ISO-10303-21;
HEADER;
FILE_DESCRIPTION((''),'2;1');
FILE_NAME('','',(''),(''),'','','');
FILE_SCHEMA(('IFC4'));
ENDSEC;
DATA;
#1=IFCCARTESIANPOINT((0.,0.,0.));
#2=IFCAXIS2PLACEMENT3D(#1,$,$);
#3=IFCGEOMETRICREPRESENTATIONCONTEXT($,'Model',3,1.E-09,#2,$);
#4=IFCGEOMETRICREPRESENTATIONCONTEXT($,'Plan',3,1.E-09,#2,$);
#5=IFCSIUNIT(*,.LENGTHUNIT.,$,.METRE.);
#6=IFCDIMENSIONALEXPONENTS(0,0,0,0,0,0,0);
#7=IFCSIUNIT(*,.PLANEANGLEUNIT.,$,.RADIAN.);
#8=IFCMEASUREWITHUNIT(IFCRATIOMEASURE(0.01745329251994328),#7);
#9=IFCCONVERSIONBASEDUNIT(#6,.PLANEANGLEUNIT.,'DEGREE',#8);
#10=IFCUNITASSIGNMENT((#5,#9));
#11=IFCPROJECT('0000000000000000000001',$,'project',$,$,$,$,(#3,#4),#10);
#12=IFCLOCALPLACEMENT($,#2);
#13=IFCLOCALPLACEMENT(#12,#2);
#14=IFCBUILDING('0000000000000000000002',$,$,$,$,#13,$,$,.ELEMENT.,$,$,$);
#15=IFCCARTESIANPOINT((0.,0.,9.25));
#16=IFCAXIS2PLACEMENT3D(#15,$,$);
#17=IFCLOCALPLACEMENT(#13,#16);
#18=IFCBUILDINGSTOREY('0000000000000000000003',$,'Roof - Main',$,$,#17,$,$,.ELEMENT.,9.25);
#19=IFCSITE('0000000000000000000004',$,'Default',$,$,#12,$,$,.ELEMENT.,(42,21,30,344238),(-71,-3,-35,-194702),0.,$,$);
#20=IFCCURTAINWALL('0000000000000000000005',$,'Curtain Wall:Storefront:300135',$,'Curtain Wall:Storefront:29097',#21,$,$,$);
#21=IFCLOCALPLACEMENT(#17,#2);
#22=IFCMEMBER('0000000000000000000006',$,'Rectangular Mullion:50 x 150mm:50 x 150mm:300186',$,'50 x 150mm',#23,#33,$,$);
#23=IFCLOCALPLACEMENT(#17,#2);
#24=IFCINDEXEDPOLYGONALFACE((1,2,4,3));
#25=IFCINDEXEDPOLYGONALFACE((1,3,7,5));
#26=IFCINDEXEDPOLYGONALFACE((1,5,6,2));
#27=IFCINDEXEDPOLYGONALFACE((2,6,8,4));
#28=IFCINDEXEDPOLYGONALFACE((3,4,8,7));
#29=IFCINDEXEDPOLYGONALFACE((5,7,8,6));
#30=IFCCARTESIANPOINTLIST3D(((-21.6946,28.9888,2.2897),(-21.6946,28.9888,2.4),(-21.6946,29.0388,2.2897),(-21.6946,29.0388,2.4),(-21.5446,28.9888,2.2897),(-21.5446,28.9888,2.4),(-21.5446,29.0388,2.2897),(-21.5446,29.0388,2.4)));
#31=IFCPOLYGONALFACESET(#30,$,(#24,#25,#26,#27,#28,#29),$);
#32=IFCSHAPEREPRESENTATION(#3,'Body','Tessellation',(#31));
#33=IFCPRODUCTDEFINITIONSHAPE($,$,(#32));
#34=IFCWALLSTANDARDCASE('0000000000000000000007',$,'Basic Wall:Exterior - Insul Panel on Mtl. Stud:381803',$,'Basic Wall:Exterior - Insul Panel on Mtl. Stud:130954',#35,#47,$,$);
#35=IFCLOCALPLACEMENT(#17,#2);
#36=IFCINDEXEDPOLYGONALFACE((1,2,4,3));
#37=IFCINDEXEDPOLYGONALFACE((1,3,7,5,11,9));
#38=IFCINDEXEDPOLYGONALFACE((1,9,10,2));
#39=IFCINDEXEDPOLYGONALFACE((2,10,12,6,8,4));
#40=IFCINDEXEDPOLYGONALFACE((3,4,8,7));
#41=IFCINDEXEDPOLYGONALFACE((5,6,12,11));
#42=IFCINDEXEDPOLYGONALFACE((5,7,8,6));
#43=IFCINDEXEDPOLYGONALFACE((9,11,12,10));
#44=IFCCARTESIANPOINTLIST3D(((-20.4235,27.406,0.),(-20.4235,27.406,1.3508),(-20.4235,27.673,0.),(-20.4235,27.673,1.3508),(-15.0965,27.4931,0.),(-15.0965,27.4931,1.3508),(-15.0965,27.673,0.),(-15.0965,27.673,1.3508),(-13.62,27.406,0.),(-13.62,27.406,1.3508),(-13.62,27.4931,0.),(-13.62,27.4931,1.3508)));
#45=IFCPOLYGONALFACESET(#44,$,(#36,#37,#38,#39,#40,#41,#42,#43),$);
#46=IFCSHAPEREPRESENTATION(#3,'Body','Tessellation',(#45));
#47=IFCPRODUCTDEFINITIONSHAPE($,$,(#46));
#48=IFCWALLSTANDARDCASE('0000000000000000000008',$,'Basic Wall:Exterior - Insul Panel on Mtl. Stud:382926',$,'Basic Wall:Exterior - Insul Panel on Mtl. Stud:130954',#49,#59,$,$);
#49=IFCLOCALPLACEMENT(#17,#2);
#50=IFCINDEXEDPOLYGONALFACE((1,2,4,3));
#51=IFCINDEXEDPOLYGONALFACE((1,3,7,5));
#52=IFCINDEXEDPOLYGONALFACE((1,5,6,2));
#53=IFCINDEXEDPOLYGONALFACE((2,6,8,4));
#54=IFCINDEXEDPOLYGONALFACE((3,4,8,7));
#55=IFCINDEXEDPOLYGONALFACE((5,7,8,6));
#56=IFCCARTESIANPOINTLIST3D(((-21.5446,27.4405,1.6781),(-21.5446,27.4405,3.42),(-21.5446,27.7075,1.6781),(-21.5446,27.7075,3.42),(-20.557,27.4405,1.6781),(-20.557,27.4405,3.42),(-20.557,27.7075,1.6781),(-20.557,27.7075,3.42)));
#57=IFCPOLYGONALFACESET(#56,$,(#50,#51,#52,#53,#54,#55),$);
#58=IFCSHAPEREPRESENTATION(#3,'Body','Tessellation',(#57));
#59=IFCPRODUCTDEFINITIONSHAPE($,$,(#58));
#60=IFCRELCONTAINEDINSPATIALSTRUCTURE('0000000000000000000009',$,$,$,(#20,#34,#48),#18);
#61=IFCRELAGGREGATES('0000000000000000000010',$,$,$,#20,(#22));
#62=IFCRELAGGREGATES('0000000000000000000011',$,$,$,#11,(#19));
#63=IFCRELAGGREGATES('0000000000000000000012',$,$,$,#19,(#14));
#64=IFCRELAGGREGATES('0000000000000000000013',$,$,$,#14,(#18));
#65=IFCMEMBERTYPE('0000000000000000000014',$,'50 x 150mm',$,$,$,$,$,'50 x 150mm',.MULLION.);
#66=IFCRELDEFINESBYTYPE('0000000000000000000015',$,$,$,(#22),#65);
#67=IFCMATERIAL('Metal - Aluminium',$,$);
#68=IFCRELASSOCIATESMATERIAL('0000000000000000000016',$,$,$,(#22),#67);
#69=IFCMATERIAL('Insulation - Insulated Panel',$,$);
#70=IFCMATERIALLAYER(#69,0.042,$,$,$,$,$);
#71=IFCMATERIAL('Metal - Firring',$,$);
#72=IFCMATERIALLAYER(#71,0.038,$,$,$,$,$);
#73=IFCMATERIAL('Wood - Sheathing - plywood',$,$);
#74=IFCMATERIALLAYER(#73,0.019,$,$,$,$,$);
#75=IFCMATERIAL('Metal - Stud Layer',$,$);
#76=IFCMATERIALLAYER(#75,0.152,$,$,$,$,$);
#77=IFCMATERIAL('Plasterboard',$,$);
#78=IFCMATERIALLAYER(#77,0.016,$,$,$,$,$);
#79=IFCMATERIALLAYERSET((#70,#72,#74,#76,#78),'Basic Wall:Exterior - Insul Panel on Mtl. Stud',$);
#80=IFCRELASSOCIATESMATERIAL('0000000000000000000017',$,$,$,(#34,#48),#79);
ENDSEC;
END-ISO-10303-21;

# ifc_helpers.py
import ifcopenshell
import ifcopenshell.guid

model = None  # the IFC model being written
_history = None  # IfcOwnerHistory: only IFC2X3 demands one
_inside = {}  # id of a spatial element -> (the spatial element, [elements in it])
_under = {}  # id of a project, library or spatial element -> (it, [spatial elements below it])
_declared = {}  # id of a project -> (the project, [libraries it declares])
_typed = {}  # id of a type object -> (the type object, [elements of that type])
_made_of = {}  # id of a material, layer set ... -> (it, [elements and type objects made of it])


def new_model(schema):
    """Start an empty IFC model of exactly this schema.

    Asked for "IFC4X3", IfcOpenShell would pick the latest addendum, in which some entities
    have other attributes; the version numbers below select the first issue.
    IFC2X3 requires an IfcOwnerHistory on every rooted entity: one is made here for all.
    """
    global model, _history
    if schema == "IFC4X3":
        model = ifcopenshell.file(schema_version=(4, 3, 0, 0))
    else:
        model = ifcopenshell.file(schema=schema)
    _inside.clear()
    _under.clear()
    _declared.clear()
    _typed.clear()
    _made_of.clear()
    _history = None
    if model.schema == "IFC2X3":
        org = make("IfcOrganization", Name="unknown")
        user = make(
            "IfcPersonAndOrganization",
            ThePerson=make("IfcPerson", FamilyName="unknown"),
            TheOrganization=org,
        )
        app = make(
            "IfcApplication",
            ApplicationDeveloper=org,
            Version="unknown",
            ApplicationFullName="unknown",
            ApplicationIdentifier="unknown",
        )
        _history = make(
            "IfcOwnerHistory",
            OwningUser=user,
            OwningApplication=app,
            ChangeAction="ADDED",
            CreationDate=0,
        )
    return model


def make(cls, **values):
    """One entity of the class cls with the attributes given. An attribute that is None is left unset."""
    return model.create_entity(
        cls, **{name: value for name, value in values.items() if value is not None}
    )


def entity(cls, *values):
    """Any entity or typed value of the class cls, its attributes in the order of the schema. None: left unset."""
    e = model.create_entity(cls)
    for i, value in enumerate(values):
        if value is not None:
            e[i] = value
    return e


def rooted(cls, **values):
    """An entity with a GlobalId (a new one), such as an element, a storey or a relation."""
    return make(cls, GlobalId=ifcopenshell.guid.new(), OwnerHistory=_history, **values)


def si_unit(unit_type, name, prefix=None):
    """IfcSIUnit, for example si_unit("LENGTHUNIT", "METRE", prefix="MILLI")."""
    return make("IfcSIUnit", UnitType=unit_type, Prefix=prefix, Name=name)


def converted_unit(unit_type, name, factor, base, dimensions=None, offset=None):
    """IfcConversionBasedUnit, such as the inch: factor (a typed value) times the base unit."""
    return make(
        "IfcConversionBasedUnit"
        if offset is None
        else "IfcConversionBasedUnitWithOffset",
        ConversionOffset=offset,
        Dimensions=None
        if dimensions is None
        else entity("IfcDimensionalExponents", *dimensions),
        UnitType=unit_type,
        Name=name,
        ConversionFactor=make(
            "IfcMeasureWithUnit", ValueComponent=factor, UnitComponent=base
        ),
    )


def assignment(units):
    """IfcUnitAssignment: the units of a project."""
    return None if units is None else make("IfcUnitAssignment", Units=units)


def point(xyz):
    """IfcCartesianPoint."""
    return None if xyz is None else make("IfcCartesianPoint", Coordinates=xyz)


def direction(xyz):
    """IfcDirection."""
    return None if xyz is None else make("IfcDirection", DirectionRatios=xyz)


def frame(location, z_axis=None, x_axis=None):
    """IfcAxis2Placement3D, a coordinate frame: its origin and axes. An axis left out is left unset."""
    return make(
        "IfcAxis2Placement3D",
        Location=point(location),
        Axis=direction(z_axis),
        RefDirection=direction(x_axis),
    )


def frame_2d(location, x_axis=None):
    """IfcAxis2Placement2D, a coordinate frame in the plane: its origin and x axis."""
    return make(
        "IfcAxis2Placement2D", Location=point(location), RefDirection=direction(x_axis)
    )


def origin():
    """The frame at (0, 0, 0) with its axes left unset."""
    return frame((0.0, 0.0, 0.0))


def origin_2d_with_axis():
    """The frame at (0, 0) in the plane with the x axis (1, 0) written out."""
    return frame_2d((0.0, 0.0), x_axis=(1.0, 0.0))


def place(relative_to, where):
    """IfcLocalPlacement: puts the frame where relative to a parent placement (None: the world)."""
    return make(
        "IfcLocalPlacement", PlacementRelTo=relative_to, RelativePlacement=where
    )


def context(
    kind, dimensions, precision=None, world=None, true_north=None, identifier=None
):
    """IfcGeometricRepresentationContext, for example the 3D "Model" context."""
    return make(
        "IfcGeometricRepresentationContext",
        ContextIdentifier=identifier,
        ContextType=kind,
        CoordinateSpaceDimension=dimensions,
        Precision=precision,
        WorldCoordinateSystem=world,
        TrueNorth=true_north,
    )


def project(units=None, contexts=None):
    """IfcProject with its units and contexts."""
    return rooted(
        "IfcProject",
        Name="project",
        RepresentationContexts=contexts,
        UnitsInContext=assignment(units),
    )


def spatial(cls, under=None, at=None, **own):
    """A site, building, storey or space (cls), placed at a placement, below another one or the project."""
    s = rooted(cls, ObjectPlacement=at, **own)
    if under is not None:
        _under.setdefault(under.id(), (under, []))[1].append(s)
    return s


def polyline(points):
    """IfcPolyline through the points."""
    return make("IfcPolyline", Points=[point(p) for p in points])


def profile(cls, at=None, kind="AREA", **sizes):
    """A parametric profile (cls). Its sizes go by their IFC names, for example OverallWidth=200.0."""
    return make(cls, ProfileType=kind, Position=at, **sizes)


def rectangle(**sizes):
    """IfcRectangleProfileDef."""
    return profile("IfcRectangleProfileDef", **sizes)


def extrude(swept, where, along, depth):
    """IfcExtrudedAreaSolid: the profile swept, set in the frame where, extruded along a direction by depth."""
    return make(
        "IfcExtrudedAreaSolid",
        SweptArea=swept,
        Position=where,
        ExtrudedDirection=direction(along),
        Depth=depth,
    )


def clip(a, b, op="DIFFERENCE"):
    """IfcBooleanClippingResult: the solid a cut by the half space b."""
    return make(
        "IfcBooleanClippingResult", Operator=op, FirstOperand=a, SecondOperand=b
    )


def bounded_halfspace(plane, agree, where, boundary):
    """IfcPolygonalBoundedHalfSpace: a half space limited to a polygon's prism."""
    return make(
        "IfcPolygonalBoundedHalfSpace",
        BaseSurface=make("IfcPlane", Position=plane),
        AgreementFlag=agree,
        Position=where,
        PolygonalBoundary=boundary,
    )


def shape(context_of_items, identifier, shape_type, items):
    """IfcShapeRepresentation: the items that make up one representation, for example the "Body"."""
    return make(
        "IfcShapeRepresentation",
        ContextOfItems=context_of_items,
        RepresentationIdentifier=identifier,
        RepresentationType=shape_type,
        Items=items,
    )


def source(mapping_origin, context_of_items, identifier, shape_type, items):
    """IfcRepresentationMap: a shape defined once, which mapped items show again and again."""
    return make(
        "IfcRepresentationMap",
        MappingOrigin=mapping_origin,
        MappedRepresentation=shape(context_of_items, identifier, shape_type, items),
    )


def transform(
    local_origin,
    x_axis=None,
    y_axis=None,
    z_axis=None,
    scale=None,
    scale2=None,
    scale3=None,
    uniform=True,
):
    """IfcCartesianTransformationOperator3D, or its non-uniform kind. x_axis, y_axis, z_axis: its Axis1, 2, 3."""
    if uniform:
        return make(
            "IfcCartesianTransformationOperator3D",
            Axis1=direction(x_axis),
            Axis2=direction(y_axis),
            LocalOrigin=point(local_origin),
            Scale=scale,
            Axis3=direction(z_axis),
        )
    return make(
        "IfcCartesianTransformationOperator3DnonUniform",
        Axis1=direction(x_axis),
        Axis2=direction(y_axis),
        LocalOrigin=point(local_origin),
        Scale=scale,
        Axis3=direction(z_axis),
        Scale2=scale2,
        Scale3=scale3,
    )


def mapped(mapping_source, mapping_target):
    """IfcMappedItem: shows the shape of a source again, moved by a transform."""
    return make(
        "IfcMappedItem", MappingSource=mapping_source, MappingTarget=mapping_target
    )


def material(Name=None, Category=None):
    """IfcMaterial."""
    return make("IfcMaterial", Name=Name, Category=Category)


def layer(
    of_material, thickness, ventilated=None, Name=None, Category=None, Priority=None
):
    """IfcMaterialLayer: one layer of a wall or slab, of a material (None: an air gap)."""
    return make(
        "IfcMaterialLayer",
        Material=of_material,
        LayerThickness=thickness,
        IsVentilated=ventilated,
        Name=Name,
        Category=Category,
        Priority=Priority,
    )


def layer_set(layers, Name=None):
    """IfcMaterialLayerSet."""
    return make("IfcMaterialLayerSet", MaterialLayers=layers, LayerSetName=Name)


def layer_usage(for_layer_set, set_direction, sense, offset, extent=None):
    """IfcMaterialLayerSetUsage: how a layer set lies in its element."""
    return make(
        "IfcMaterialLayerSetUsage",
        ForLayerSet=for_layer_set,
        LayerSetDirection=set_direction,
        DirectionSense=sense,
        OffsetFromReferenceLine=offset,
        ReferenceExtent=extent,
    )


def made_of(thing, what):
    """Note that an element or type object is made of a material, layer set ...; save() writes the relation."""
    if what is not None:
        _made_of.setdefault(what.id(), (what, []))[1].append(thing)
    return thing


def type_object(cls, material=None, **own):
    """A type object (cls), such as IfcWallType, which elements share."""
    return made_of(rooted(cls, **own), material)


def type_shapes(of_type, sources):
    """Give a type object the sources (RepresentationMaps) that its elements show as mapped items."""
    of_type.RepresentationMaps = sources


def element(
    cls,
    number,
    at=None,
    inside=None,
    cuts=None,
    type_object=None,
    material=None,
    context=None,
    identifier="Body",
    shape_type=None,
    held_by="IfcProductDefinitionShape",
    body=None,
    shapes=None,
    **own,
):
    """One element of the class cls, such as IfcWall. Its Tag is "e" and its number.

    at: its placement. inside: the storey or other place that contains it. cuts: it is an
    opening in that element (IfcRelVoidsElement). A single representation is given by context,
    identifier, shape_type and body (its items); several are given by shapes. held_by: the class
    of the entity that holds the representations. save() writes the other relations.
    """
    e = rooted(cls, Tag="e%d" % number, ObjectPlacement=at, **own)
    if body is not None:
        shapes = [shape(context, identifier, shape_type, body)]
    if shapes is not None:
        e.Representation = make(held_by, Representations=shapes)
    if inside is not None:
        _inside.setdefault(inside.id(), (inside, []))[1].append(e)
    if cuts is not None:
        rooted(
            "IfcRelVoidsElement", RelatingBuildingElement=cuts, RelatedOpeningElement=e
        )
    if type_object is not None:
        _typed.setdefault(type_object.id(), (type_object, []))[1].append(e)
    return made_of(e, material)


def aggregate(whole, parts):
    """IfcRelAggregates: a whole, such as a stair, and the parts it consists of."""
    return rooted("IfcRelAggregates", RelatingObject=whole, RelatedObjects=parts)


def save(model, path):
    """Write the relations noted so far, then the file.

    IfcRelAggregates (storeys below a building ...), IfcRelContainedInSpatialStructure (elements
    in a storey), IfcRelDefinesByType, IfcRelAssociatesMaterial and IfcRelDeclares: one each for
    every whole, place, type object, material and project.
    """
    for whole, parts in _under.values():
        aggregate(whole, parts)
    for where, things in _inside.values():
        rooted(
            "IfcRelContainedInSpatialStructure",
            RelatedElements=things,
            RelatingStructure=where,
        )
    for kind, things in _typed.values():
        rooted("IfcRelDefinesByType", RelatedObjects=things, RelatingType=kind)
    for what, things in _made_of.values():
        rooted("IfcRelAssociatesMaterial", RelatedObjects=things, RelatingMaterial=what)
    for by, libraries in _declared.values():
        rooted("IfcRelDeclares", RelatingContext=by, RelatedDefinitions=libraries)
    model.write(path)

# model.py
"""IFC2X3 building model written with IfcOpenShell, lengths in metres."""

from ifc_helpers import new_model, entity, si_unit, converted_unit, frame, frame_2d, origin, origin_2d_with_axis, place, context, project, spatial, polyline, rectangle, extrude, clip, bounded_halfspace, source, transform, mapped, material, layer, layer_set, layer_usage, type_object, type_shapes, element, aggregate, save


model = new_model("IFC2X3")

# Units and contexts
model_context = context("Model", 3, precision=1e-09, world=origin())
plan_context = context("Plan", 3, precision=1e-09, world=origin())
ifc_project = project(units=[si_unit("LENGTHUNIT", "METRE"), converted_unit("PLANEANGLEUNIT", "DEGREE", entity("IfcRatioMeasure", 0.01745329251994328), si_unit("PLANEANGLEUNIT", "RADIAN"), dimensions=[0, 0, 0, 0, 0, 0, 0])], contexts=[model_context, plan_context])

# Site, building, storey
site_placement = place(None, origin())
site = spatial("IfcSite", under=ifc_project, at=site_placement, Name="Default", CompositionType="ELEMENT", RefLatitude=(42, 21, 30, 344238), RefLongitude=(-71, -3, -35, -194702), RefElevation=0.0)
building_placement = place(site_placement, origin())
building = spatial("IfcBuilding", under=site, at=building_placement, CompositionType="ELEMENT")
storey_placement = place(building_placement, frame((0.0, 0.0, 9.25)))
storey = spatial("IfcBuildingStorey", under=building, at=storey_placement, Name="Roof - Main", CompositionType="ELEMENT", Elevation=9.25)

# Curtain wall, member
ifc_material_1 = material(Name="Metal - Aluminium")
curtain_wall_1_placement = place(storey_placement, origin())
curtain_wall_1 = element("IfcCurtainWall", 1, at=curtain_wall_1_placement, inside=storey, Name="Curtain Wall:Storefront:300135", ObjectType="Curtain Wall:Storefront:29097")
member_type_1 = type_object("IfcMemberType", Name="50 x 150mm", ElementType="50 x 150mm", PredefinedType="MULLION")
shared_shape_1 = source(origin(), model_context, "Body", "SweptSolid", [
    extrude(rectangle(XDim=0.05, YDim=0.15, at=origin_2d_with_axis()), frame((0.0, 0.0, -0.1103), z_axis=(0.0, 0.0, 1.0), x_axis=(-1.0, 0.0, 0.0)), (0.0, 0.0, 1.0), 0.1103),
])
type_shapes(member_type_1, [shared_shape_1])
member_1_placement = place(storey_placement, frame((-21.6196, 29.0138, 2.2897), z_axis=(0.0, 0.0, -1.0), x_axis=(0.0, -1.0, 0.0)))
member_1 = element("IfcMember", 2, at=member_1_placement, type_object=member_type_1, material=ifc_material_1, Name="Rectangular Mullion:50 x 150mm:50 x 150mm:300186", ObjectType="50 x 150mm", context=model_context, shape_type="MappedRepresentation", body=[
    mapped(shared_shape_1, transform((0.0, 0.0, 0.0), scale=1.0)),
])

aggregate(curtain_wall_1, [member_1])

# Walls
ifc_material_2 = material(Name="Insulation - Insulated Panel")
ifc_layer_1 = layer(ifc_material_2, 0.042)
ifc_material_3 = material(Name="Metal - Firring")
ifc_layer_2 = layer(ifc_material_3, 0.038)
ifc_material_4 = material(Name="Wood - Sheathing - plywood")
ifc_layer_3 = layer(ifc_material_4, 0.019)
ifc_material_5 = material(Name="Metal - Stud Layer")
ifc_layer_4 = layer(ifc_material_5, 0.152)
ifc_material_6 = material(Name="Plasterboard")
ifc_layer_5 = layer(ifc_material_6, 0.016)
ifc_layer_set = layer_set([ifc_layer_1, ifc_layer_2, ifc_layer_3, ifc_layer_4, ifc_layer_5], Name="Basic Wall:Exterior - Insul Panel on Mtl. Stud")
ifc_layer_usage_1 = layer_usage(ifc_layer_set, "AXIS2", "POSITIVE", -0.1335)
wall_1_placement = place(storey_placement, frame((-20.4235, 27.5395, 0.0)))
element("IfcWallStandardCase", 3, at=wall_1_placement, inside=storey, material=ifc_layer_usage_1, Name="Basic Wall:Exterior - Insul Panel on Mtl. Stud:381803", ObjectType="Basic Wall:Exterior - Insul Panel on Mtl. Stud:130954", context=model_context, shape_type="Clipping", body=[
    clip(clip(extrude(rectangle(XDim=6.8035, YDim=0.267, at=frame_2d((3.4018, 0.0), x_axis=(-1.0, 0.0))), origin(), (0.0, 0.0, 1.0), 1.3508), bounded_halfspace(frame((5.327, -0.0464, 0.0), z_axis=(0.0, -1.0, 0.0), x_axis=(1.0, 0.0, 0.0)), True, frame((5.327, -0.0464, 0.0), z_axis=(0.0, -1.0, 0.0), x_axis=(1.0, 0.0, 0.0)), polyline([(0.0, 0.0), (1.4765, 0.0), (1.4765, 0.457), (1.4765, 1.3508), (0.0, 1.3508), (0.0, 0.0)]))), bounded_halfspace(frame((5.327, -0.0464, 1.3508), z_axis=(-1.0, 0.0, 0.0), x_axis=(0.0, -1.0, 0.0)), True, frame((5.327, -0.0464, 1.3508), z_axis=(-1.0, 0.0, 0.0), x_axis=(0.0, -1.0, 0.0)), polyline([(0.0, 0.0), (-0.1799, 0.0), (-0.1799, -0.0008), (-0.1799, -1.3508), (0.0, -1.3508), (0.0, 0.0)]))),
])
ifc_layer_usage_2 = layer_usage(ifc_layer_set, "AXIS2", "NEGATIVE", 0.1335)
wall_2_placement = place(storey_placement, frame((-21.5446, 27.574, 1.6781)))
element("IfcWallStandardCase", 4, at=wall_2_placement, inside=storey, material=ifc_layer_usage_2, Name="Basic Wall:Exterior - Insul Panel on Mtl. Stud:382926", ObjectType="Basic Wall:Exterior - Insul Panel on Mtl. Stud:130954", context=model_context, shape_type="SweptSolid", body=[
    extrude(rectangle(XDim=0.9876, YDim=0.267, at=frame_2d((0.4938, 0.0), x_axis=(-1.0, 0.0))), origin(), (0.0, 0.0, 1.0), 1.7419),
])

save(model, "model.ifc")
